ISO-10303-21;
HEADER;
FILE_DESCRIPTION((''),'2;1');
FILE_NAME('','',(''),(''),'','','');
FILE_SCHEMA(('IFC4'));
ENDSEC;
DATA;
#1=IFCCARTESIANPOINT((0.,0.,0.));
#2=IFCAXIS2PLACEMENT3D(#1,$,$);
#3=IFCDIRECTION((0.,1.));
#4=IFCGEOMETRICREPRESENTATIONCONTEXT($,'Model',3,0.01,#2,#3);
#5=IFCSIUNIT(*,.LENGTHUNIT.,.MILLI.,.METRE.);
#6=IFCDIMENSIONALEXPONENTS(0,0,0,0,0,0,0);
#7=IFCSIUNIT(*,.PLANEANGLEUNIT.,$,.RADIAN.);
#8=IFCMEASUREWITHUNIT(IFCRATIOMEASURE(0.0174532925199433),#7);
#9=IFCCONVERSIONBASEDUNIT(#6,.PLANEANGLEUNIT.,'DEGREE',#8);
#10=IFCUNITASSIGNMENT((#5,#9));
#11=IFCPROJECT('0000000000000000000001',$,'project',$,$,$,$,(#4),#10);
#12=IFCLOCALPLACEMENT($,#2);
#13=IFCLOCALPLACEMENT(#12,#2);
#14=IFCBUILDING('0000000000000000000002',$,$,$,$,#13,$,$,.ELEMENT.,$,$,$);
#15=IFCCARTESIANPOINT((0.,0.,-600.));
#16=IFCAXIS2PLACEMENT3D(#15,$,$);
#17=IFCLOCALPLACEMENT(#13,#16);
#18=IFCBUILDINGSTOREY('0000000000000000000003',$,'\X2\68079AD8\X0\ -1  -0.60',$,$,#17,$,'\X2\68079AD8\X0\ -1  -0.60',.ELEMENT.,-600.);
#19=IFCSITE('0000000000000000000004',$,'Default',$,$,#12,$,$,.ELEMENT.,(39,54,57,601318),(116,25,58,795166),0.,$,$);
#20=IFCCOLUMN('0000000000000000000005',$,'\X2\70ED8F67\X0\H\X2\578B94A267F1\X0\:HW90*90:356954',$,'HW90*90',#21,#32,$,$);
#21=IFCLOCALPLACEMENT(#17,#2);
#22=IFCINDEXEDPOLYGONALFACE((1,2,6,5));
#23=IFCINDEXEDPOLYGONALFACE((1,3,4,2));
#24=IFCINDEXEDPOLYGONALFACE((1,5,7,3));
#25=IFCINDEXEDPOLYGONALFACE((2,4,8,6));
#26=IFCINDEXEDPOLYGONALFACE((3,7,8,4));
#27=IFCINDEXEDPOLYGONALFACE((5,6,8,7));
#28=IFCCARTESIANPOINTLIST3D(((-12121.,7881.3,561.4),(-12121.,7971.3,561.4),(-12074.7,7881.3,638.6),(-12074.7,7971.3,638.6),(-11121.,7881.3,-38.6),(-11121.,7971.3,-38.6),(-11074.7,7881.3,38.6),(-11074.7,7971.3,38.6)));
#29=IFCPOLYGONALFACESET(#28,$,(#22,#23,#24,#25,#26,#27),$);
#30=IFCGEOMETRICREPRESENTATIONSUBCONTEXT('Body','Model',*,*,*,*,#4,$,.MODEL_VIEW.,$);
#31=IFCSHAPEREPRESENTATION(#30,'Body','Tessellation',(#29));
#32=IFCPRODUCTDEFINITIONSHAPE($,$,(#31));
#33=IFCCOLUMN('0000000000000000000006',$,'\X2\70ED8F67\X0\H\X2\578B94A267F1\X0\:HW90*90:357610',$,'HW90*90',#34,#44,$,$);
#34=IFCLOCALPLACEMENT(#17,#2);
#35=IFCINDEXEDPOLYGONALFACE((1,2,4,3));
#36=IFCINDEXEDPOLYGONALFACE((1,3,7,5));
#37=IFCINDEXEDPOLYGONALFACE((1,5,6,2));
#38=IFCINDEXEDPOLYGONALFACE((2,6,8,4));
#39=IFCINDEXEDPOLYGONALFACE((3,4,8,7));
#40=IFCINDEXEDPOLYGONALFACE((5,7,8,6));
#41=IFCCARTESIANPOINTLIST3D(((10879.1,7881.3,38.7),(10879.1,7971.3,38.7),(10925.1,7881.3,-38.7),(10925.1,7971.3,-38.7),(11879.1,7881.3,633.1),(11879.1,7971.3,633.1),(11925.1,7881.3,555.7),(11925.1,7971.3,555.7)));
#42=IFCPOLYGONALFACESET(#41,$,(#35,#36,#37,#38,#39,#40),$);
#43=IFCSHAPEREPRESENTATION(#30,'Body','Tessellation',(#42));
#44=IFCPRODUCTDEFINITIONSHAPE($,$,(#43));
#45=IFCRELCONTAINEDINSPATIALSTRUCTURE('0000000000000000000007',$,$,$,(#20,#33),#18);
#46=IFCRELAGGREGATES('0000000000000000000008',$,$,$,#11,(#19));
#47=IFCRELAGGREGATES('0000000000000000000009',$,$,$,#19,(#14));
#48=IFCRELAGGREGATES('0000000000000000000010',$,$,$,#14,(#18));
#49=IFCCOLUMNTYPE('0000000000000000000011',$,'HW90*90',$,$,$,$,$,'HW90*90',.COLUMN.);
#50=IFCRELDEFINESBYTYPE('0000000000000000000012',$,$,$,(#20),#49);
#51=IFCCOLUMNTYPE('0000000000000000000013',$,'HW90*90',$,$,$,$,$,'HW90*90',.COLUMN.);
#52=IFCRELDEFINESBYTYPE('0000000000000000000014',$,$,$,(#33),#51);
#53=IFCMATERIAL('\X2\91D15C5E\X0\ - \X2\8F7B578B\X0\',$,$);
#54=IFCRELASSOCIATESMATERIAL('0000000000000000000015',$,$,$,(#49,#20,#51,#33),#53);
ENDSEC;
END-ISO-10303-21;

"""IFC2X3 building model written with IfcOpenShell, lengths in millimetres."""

from ifc_helpers import new_model, entity, si_unit, converted_unit, direction, frame, frame_2d, origin, place, context, subcontext, project, spatial, rectangle, extrude, source, transform, mapped, material, type_object, type_shapes, element, save


model = new_model("IFC2X3")

# Units and contexts
model_context = context("Model", 3, precision=0.01, world=origin(), true_north=direction((0.0, 1.0)))
body_context = subcontext(model_context, "Body", "Model", "MODEL_VIEW")
ifc_project = project(units=[si_unit("LENGTHUNIT", "METRE", prefix="MILLI"), converted_unit("PLANEANGLEUNIT", "DEGREE", entity("IfcRatioMeasure", 0.0174532925199433), si_unit("PLANEANGLEUNIT", "RADIAN"), dimensions=[0, 0, 0, 0, 0, 0, 0])], contexts=[model_context])

# Site, building, storey
site_placement = place(None, origin())
site = spatial("IfcSite", under=ifc_project, at=site_placement, Name="Default", CompositionType="ELEMENT", RefLatitude=(39, 54, 57, 601318), RefLongitude=(116, 25, 58, 795166), RefElevation=0.0)
building_placement = place(site_placement, origin())
building = spatial("IfcBuilding", under=site, at=building_placement, CompositionType="ELEMENT")
storey_placement = place(building_placement, frame((0.0, 0.0, -600.0)))
storey = spatial("IfcBuildingStorey", under=building, at=storey_placement, Name="标高 -1  -0.60", LongName="标高 -1  -0.60", CompositionType="ELEMENT", Elevation=-600.0)

# Columns
ifc_material = material(Name="金属 - 轻型")
column_type_1 = type_object("IfcColumnType", Name="HW90*90", ElementType="HW90*90", PredefinedType="COLUMN", material=ifc_material)
shared_shape_1 = source(origin(), body_context, "Body", "SweptSolid", [
    extrude(rectangle(XDim=1166.2, YDim=90.0, at=frame_2d((0.0, 0.0), x_axis=(1.0, 0.0))), frame((-11621.0, 7926.3, -338.6), z_axis=(0.514496, 0.0, 0.857493), x_axis=(0.857493, 0.0, -0.514496)), (0.0, 0.0, 1.0), 90.0),
])
type_shapes(column_type_1, [shared_shape_1])
column_1_placement = place(storey_placement, frame((0.0, 0.0, 600.0)))
element("IfcColumn", 1, at=column_1_placement, inside=storey, type_object=column_type_1, material=ifc_material, Name="热轧H型钢柱:HW90*90:356954", ObjectType="HW90*90", context=body_context, shape_type="MappedRepresentation", body=[
    mapped(shared_shape_1, transform((0.0, 0.0, 0.0), scale=1.0)),
])
column_type_2 = type_object("IfcColumnType", Name="HW90*90", ElementType="HW90*90", PredefinedType="COLUMN", material=ifc_material)
shared_shape_2 = source(origin(), body_context, "Body", "SweptSolid", [
    extrude(rectangle(XDim=1163.3, YDim=90.0, at=frame_2d((0.0, 0.0), x_axis=(1.0, 0.0))), frame((11425.1, 7926.3, -341.5), z_axis=(-0.510962, 0.0, 0.859603), x_axis=(-0.859603, 0.0, -0.510962)), (0.0, 0.0, 1.0), 90.0),
])
type_shapes(column_type_2, [shared_shape_2])
column_2_placement = place(storey_placement, frame((0.0, 0.0, 600.0)))
element("IfcColumn", 2, at=column_2_placement, inside=storey, type_object=column_type_2, material=ifc_material, Name="热轧H型钢柱:HW90*90:357610", ObjectType="HW90*90", context=body_context, shape_type="MappedRepresentation", body=[
    mapped(shared_shape_2, transform((0.0, 0.0, 0.0), scale=1.0)),
])

save(model, "model.ifc")
